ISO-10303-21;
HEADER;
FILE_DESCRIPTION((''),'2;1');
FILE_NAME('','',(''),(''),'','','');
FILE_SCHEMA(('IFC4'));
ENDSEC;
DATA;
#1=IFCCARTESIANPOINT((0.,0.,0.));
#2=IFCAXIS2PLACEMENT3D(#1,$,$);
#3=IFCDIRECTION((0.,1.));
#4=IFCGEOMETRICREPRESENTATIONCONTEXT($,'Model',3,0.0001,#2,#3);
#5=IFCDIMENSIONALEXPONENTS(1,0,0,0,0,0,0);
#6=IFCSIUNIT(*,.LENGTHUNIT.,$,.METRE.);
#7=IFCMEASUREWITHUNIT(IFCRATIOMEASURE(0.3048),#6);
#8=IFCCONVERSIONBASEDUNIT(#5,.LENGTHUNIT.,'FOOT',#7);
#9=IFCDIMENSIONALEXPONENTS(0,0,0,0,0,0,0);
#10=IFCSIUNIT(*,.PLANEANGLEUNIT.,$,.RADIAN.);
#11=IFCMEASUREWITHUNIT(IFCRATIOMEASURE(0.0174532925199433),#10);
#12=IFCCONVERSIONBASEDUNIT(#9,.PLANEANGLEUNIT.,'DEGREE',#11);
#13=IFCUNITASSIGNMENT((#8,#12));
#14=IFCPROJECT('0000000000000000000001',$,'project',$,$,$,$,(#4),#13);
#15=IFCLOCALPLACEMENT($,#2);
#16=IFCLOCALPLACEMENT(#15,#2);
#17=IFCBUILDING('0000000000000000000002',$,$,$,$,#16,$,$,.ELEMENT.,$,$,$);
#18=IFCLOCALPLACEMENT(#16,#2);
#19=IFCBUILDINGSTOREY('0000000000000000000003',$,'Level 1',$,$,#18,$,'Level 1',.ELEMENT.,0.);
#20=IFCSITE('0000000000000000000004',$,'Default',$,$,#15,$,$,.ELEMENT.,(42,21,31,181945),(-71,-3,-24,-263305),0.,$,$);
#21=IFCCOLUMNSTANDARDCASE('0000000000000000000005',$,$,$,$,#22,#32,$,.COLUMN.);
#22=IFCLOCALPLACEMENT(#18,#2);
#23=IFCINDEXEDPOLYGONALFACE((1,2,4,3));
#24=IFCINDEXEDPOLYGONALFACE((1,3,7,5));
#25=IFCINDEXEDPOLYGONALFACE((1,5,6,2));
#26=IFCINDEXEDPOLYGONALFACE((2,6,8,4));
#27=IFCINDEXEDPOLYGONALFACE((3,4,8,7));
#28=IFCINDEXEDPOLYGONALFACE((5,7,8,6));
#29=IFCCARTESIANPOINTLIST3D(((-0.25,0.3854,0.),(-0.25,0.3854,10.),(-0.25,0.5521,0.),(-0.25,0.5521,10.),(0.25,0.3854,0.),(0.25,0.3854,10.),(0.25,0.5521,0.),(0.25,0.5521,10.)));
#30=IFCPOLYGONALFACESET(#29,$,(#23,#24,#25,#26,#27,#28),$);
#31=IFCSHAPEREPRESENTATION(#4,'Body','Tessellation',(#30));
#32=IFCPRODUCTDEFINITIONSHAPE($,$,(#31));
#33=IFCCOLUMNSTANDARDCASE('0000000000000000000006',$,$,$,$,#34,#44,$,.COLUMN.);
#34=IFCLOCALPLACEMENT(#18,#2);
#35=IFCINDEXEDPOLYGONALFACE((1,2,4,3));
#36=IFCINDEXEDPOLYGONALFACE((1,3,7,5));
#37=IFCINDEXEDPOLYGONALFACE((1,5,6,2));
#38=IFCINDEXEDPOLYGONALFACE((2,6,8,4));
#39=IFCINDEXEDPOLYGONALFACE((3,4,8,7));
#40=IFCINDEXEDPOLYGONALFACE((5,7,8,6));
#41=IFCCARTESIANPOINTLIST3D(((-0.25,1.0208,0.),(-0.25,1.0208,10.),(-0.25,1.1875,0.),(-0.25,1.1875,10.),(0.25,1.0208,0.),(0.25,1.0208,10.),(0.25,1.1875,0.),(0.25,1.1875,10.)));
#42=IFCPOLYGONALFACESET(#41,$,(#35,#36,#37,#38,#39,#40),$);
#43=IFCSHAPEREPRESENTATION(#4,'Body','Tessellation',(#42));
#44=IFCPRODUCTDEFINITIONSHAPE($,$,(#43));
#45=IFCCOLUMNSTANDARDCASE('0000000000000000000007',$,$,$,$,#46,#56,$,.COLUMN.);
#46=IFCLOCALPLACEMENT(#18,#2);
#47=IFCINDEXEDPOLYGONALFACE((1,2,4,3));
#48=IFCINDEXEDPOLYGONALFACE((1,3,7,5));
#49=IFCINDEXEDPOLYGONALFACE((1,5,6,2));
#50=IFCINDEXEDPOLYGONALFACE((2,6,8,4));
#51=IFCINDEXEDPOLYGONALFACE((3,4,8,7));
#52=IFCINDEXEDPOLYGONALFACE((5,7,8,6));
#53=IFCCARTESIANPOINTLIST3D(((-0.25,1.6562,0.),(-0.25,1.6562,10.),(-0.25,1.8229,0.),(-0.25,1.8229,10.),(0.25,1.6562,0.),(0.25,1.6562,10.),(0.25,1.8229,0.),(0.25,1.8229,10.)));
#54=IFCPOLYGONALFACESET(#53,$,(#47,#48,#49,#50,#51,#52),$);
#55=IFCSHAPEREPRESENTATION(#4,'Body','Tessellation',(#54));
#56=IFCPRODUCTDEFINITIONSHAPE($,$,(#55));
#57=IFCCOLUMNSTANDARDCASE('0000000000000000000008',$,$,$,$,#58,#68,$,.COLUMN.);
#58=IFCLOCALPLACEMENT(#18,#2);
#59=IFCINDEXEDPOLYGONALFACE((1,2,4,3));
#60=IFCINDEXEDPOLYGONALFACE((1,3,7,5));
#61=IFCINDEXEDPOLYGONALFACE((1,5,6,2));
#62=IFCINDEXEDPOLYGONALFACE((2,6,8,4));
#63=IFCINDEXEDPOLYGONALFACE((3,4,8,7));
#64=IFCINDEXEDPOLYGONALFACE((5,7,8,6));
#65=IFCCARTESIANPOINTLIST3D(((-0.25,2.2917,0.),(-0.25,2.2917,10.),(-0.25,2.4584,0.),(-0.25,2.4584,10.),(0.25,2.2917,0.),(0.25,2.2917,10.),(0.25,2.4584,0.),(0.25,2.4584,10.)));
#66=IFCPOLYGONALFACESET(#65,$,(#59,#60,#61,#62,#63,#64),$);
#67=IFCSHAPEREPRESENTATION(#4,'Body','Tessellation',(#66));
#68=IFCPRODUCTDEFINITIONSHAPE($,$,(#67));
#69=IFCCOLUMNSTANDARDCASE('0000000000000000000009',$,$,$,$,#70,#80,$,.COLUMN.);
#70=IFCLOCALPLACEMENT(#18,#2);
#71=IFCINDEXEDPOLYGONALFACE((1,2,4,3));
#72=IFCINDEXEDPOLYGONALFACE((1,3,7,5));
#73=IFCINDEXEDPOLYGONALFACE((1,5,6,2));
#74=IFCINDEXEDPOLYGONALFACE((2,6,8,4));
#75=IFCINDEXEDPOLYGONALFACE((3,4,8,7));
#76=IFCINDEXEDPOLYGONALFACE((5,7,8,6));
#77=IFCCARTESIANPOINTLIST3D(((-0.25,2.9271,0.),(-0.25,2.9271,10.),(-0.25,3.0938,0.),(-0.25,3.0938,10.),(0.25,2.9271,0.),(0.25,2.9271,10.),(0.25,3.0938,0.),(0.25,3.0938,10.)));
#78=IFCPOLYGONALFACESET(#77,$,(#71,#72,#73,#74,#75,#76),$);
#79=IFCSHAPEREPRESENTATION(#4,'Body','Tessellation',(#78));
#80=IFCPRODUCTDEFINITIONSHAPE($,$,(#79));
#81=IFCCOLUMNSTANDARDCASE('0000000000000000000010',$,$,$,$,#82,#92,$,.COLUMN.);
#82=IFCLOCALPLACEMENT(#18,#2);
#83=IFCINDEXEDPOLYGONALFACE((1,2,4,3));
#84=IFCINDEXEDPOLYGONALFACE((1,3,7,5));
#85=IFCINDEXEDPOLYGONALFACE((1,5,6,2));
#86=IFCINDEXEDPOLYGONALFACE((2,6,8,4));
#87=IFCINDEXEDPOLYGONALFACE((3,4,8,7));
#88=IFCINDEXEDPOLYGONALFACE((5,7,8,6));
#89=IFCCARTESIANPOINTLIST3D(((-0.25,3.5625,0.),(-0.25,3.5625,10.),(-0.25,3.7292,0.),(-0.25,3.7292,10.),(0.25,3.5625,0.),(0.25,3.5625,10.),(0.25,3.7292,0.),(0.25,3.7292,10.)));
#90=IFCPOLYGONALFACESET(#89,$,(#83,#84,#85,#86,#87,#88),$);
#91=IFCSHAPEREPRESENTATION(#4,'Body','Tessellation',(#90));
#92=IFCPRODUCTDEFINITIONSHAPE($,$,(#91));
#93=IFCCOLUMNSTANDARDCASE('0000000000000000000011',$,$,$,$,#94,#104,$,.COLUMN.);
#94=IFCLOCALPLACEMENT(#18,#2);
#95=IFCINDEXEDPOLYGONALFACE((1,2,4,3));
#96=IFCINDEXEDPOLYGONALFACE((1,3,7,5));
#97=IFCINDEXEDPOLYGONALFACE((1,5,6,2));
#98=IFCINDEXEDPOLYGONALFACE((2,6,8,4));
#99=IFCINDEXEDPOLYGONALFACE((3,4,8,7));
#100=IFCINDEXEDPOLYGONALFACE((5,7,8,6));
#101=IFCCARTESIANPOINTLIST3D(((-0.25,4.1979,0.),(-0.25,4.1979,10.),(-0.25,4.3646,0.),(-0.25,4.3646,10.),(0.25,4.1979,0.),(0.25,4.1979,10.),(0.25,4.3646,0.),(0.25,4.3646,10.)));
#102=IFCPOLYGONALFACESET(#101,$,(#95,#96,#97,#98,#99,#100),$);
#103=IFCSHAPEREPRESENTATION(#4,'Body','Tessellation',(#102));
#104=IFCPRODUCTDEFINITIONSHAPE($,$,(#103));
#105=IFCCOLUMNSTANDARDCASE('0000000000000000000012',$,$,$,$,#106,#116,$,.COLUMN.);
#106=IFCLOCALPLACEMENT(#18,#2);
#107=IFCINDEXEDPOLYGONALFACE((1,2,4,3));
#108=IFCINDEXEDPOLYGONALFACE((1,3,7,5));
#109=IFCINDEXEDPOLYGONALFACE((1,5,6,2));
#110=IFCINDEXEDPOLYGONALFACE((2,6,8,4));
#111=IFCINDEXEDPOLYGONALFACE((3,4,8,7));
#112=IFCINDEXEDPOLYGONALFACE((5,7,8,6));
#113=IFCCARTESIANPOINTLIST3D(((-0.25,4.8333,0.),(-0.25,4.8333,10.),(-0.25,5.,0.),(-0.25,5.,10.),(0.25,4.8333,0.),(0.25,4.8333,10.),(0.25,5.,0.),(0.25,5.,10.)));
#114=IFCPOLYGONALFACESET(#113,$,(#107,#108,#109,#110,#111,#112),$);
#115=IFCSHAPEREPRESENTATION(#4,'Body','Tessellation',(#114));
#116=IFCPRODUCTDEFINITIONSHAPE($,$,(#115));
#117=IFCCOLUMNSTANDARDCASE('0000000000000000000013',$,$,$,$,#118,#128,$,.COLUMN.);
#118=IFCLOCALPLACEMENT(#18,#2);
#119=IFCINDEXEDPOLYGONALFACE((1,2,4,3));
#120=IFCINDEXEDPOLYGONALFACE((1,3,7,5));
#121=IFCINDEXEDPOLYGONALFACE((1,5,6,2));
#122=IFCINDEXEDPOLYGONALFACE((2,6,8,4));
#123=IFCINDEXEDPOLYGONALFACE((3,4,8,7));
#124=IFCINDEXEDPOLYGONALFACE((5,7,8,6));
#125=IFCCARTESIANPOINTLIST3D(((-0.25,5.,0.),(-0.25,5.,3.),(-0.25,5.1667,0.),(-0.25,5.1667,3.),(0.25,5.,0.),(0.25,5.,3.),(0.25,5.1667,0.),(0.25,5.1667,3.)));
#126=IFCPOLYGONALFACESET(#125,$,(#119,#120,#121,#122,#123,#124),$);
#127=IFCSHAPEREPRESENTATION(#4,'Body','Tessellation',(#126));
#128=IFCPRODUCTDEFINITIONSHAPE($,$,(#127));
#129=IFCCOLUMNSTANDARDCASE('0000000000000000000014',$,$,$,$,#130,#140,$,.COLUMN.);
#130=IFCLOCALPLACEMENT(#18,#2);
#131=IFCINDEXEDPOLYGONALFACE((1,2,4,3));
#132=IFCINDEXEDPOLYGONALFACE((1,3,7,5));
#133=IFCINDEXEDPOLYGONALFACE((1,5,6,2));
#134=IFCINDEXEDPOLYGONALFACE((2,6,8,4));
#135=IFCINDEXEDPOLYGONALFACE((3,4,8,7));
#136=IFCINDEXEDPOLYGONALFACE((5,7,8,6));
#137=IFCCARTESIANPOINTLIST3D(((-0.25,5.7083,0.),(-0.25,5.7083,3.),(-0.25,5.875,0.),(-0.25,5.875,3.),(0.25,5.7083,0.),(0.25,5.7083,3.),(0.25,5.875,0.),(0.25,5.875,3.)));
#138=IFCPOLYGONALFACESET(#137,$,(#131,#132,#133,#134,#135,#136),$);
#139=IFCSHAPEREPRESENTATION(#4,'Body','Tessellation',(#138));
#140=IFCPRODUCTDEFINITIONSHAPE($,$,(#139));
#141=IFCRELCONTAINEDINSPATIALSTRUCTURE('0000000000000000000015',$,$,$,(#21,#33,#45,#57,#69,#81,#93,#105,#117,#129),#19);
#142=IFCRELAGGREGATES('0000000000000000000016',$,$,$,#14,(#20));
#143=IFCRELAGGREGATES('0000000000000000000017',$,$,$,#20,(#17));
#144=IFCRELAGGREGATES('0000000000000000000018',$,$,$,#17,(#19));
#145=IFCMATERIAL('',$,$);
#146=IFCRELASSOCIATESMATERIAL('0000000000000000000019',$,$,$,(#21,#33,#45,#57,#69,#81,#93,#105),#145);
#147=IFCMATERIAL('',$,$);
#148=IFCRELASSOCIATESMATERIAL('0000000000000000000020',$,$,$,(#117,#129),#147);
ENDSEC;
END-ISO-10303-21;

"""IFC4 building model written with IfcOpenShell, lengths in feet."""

from ifc_helpers import new_model, entity, si_unit, converted_unit, direction, frame, origin, place, context, project, spatial, rectangle, extrude, material, element, save


model = new_model("IFC4")

# Units and contexts
model_context = context("Model", 3, precision=0.0001, world=origin(), true_north=direction((0.0, 1.0)))
ifc_project = project(units=[converted_unit("LENGTHUNIT", "FOOT", entity("IfcRatioMeasure", 0.3048), si_unit("LENGTHUNIT", "METRE"), dimensions=[1, 0, 0, 0, 0, 0, 0]), converted_unit("PLANEANGLEUNIT", "DEGREE", entity("IfcRatioMeasure", 0.0174532925199433), si_unit("PLANEANGLEUNIT", "RADIAN"), dimensions=[0, 0, 0, 0, 0, 0, 0])], contexts=[model_context])

# Site, building, storey
site_placement = place(None, origin())
site = spatial("IfcSite", under=ifc_project, at=site_placement, Name="Default", CompositionType="ELEMENT", RefLatitude=(42, 21, 31, 181945), RefLongitude=(-71, -3, -24, -263305), RefElevation=0.0)
building_placement = place(site_placement, origin())
building = spatial("IfcBuilding", under=site, at=building_placement, CompositionType="ELEMENT")
storey_placement = place(building_placement, origin())
storey = spatial("IfcBuildingStorey", under=building, at=storey_placement, Name="Level 1", LongName="Level 1", CompositionType="ELEMENT", Elevation=0.0)

# Columns
ifc_material_1 = material(Name="")
placement_1 = place(storey_placement, frame((0.0, -0.25, 0.0), z_axis=(0.0, 0.0, 1.0), x_axis=(0.0, 1.0, 0.0)))
for number, where, z_axis, x_axis in (
    (1, (0.7188, 0.0, 0.0), (0.0, 0.0, 1.0), (1.0, 0.0, 0.0)),
    (2, (1.3542, 0.0, 0.0), (0.0, 0.0, 1.0), (1.0, 0.0, 0.0)),
    (3, (1.9896, 0.0, 0.0), (0.0, 0.0, 1.0), (1.0, 0.0, 0.0)),
    (4, (2.625, 0.0, 0.0), (0.0, 0.0, 1.0), (1.0, 0.0, 0.0)),
    (5, (3.2604, 0.0, 0.0), (0.0, 0.0, 1.0), (1.0, 0.0, 0.0)),
    (6, (3.8958, 0.0, 0.0), (0.0, 0.0, 1.0), (1.0, 0.0, 0.0)),
    (7, (4.5312, 0.0, 0.0), (0.0, 0.0, 1.0), (1.0, 0.0, 0.0)),
    (8, (5.1667, 0.0, 0.0), (0.0, 0.0, 1.0), (1.0, 0.0, 0.0)),
):
    element("IfcColumnStandardCase", number, at=place(placement_1, frame(where, z_axis=z_axis, x_axis=x_axis)), inside=storey, material=ifc_material_1, PredefinedType="COLUMN", context=model_context, shape_type="SweptSolid", body=[
        extrude(rectangle(XDim=0.1667, YDim=0.5), origin(), (0.0, 0.0, 1.0), 10.0),
    ])
ifc_material_2 = material(Name="")
for number, where, z_axis, x_axis in (
    (9, (5.3334, 0.0, 0.0), (0.0, 0.0, 1.0), (1.0, 0.0, 0.0)),
    (10, (6.0417, 0.0, 0.0), (0.0, 0.0, 1.0), (1.0, 0.0, 0.0)),
):
    element("IfcColumnStandardCase", number, at=place(placement_1, frame(where, z_axis=z_axis, x_axis=x_axis)), inside=storey, material=ifc_material_2, PredefinedType="COLUMN", context=model_context, shape_type="SweptSolid", body=[
        extrude(rectangle(XDim=0.1667, YDim=0.5), origin(), (0.0, 0.0, 1.0), 3.0),
    ])

save(model, "model.ifc")
